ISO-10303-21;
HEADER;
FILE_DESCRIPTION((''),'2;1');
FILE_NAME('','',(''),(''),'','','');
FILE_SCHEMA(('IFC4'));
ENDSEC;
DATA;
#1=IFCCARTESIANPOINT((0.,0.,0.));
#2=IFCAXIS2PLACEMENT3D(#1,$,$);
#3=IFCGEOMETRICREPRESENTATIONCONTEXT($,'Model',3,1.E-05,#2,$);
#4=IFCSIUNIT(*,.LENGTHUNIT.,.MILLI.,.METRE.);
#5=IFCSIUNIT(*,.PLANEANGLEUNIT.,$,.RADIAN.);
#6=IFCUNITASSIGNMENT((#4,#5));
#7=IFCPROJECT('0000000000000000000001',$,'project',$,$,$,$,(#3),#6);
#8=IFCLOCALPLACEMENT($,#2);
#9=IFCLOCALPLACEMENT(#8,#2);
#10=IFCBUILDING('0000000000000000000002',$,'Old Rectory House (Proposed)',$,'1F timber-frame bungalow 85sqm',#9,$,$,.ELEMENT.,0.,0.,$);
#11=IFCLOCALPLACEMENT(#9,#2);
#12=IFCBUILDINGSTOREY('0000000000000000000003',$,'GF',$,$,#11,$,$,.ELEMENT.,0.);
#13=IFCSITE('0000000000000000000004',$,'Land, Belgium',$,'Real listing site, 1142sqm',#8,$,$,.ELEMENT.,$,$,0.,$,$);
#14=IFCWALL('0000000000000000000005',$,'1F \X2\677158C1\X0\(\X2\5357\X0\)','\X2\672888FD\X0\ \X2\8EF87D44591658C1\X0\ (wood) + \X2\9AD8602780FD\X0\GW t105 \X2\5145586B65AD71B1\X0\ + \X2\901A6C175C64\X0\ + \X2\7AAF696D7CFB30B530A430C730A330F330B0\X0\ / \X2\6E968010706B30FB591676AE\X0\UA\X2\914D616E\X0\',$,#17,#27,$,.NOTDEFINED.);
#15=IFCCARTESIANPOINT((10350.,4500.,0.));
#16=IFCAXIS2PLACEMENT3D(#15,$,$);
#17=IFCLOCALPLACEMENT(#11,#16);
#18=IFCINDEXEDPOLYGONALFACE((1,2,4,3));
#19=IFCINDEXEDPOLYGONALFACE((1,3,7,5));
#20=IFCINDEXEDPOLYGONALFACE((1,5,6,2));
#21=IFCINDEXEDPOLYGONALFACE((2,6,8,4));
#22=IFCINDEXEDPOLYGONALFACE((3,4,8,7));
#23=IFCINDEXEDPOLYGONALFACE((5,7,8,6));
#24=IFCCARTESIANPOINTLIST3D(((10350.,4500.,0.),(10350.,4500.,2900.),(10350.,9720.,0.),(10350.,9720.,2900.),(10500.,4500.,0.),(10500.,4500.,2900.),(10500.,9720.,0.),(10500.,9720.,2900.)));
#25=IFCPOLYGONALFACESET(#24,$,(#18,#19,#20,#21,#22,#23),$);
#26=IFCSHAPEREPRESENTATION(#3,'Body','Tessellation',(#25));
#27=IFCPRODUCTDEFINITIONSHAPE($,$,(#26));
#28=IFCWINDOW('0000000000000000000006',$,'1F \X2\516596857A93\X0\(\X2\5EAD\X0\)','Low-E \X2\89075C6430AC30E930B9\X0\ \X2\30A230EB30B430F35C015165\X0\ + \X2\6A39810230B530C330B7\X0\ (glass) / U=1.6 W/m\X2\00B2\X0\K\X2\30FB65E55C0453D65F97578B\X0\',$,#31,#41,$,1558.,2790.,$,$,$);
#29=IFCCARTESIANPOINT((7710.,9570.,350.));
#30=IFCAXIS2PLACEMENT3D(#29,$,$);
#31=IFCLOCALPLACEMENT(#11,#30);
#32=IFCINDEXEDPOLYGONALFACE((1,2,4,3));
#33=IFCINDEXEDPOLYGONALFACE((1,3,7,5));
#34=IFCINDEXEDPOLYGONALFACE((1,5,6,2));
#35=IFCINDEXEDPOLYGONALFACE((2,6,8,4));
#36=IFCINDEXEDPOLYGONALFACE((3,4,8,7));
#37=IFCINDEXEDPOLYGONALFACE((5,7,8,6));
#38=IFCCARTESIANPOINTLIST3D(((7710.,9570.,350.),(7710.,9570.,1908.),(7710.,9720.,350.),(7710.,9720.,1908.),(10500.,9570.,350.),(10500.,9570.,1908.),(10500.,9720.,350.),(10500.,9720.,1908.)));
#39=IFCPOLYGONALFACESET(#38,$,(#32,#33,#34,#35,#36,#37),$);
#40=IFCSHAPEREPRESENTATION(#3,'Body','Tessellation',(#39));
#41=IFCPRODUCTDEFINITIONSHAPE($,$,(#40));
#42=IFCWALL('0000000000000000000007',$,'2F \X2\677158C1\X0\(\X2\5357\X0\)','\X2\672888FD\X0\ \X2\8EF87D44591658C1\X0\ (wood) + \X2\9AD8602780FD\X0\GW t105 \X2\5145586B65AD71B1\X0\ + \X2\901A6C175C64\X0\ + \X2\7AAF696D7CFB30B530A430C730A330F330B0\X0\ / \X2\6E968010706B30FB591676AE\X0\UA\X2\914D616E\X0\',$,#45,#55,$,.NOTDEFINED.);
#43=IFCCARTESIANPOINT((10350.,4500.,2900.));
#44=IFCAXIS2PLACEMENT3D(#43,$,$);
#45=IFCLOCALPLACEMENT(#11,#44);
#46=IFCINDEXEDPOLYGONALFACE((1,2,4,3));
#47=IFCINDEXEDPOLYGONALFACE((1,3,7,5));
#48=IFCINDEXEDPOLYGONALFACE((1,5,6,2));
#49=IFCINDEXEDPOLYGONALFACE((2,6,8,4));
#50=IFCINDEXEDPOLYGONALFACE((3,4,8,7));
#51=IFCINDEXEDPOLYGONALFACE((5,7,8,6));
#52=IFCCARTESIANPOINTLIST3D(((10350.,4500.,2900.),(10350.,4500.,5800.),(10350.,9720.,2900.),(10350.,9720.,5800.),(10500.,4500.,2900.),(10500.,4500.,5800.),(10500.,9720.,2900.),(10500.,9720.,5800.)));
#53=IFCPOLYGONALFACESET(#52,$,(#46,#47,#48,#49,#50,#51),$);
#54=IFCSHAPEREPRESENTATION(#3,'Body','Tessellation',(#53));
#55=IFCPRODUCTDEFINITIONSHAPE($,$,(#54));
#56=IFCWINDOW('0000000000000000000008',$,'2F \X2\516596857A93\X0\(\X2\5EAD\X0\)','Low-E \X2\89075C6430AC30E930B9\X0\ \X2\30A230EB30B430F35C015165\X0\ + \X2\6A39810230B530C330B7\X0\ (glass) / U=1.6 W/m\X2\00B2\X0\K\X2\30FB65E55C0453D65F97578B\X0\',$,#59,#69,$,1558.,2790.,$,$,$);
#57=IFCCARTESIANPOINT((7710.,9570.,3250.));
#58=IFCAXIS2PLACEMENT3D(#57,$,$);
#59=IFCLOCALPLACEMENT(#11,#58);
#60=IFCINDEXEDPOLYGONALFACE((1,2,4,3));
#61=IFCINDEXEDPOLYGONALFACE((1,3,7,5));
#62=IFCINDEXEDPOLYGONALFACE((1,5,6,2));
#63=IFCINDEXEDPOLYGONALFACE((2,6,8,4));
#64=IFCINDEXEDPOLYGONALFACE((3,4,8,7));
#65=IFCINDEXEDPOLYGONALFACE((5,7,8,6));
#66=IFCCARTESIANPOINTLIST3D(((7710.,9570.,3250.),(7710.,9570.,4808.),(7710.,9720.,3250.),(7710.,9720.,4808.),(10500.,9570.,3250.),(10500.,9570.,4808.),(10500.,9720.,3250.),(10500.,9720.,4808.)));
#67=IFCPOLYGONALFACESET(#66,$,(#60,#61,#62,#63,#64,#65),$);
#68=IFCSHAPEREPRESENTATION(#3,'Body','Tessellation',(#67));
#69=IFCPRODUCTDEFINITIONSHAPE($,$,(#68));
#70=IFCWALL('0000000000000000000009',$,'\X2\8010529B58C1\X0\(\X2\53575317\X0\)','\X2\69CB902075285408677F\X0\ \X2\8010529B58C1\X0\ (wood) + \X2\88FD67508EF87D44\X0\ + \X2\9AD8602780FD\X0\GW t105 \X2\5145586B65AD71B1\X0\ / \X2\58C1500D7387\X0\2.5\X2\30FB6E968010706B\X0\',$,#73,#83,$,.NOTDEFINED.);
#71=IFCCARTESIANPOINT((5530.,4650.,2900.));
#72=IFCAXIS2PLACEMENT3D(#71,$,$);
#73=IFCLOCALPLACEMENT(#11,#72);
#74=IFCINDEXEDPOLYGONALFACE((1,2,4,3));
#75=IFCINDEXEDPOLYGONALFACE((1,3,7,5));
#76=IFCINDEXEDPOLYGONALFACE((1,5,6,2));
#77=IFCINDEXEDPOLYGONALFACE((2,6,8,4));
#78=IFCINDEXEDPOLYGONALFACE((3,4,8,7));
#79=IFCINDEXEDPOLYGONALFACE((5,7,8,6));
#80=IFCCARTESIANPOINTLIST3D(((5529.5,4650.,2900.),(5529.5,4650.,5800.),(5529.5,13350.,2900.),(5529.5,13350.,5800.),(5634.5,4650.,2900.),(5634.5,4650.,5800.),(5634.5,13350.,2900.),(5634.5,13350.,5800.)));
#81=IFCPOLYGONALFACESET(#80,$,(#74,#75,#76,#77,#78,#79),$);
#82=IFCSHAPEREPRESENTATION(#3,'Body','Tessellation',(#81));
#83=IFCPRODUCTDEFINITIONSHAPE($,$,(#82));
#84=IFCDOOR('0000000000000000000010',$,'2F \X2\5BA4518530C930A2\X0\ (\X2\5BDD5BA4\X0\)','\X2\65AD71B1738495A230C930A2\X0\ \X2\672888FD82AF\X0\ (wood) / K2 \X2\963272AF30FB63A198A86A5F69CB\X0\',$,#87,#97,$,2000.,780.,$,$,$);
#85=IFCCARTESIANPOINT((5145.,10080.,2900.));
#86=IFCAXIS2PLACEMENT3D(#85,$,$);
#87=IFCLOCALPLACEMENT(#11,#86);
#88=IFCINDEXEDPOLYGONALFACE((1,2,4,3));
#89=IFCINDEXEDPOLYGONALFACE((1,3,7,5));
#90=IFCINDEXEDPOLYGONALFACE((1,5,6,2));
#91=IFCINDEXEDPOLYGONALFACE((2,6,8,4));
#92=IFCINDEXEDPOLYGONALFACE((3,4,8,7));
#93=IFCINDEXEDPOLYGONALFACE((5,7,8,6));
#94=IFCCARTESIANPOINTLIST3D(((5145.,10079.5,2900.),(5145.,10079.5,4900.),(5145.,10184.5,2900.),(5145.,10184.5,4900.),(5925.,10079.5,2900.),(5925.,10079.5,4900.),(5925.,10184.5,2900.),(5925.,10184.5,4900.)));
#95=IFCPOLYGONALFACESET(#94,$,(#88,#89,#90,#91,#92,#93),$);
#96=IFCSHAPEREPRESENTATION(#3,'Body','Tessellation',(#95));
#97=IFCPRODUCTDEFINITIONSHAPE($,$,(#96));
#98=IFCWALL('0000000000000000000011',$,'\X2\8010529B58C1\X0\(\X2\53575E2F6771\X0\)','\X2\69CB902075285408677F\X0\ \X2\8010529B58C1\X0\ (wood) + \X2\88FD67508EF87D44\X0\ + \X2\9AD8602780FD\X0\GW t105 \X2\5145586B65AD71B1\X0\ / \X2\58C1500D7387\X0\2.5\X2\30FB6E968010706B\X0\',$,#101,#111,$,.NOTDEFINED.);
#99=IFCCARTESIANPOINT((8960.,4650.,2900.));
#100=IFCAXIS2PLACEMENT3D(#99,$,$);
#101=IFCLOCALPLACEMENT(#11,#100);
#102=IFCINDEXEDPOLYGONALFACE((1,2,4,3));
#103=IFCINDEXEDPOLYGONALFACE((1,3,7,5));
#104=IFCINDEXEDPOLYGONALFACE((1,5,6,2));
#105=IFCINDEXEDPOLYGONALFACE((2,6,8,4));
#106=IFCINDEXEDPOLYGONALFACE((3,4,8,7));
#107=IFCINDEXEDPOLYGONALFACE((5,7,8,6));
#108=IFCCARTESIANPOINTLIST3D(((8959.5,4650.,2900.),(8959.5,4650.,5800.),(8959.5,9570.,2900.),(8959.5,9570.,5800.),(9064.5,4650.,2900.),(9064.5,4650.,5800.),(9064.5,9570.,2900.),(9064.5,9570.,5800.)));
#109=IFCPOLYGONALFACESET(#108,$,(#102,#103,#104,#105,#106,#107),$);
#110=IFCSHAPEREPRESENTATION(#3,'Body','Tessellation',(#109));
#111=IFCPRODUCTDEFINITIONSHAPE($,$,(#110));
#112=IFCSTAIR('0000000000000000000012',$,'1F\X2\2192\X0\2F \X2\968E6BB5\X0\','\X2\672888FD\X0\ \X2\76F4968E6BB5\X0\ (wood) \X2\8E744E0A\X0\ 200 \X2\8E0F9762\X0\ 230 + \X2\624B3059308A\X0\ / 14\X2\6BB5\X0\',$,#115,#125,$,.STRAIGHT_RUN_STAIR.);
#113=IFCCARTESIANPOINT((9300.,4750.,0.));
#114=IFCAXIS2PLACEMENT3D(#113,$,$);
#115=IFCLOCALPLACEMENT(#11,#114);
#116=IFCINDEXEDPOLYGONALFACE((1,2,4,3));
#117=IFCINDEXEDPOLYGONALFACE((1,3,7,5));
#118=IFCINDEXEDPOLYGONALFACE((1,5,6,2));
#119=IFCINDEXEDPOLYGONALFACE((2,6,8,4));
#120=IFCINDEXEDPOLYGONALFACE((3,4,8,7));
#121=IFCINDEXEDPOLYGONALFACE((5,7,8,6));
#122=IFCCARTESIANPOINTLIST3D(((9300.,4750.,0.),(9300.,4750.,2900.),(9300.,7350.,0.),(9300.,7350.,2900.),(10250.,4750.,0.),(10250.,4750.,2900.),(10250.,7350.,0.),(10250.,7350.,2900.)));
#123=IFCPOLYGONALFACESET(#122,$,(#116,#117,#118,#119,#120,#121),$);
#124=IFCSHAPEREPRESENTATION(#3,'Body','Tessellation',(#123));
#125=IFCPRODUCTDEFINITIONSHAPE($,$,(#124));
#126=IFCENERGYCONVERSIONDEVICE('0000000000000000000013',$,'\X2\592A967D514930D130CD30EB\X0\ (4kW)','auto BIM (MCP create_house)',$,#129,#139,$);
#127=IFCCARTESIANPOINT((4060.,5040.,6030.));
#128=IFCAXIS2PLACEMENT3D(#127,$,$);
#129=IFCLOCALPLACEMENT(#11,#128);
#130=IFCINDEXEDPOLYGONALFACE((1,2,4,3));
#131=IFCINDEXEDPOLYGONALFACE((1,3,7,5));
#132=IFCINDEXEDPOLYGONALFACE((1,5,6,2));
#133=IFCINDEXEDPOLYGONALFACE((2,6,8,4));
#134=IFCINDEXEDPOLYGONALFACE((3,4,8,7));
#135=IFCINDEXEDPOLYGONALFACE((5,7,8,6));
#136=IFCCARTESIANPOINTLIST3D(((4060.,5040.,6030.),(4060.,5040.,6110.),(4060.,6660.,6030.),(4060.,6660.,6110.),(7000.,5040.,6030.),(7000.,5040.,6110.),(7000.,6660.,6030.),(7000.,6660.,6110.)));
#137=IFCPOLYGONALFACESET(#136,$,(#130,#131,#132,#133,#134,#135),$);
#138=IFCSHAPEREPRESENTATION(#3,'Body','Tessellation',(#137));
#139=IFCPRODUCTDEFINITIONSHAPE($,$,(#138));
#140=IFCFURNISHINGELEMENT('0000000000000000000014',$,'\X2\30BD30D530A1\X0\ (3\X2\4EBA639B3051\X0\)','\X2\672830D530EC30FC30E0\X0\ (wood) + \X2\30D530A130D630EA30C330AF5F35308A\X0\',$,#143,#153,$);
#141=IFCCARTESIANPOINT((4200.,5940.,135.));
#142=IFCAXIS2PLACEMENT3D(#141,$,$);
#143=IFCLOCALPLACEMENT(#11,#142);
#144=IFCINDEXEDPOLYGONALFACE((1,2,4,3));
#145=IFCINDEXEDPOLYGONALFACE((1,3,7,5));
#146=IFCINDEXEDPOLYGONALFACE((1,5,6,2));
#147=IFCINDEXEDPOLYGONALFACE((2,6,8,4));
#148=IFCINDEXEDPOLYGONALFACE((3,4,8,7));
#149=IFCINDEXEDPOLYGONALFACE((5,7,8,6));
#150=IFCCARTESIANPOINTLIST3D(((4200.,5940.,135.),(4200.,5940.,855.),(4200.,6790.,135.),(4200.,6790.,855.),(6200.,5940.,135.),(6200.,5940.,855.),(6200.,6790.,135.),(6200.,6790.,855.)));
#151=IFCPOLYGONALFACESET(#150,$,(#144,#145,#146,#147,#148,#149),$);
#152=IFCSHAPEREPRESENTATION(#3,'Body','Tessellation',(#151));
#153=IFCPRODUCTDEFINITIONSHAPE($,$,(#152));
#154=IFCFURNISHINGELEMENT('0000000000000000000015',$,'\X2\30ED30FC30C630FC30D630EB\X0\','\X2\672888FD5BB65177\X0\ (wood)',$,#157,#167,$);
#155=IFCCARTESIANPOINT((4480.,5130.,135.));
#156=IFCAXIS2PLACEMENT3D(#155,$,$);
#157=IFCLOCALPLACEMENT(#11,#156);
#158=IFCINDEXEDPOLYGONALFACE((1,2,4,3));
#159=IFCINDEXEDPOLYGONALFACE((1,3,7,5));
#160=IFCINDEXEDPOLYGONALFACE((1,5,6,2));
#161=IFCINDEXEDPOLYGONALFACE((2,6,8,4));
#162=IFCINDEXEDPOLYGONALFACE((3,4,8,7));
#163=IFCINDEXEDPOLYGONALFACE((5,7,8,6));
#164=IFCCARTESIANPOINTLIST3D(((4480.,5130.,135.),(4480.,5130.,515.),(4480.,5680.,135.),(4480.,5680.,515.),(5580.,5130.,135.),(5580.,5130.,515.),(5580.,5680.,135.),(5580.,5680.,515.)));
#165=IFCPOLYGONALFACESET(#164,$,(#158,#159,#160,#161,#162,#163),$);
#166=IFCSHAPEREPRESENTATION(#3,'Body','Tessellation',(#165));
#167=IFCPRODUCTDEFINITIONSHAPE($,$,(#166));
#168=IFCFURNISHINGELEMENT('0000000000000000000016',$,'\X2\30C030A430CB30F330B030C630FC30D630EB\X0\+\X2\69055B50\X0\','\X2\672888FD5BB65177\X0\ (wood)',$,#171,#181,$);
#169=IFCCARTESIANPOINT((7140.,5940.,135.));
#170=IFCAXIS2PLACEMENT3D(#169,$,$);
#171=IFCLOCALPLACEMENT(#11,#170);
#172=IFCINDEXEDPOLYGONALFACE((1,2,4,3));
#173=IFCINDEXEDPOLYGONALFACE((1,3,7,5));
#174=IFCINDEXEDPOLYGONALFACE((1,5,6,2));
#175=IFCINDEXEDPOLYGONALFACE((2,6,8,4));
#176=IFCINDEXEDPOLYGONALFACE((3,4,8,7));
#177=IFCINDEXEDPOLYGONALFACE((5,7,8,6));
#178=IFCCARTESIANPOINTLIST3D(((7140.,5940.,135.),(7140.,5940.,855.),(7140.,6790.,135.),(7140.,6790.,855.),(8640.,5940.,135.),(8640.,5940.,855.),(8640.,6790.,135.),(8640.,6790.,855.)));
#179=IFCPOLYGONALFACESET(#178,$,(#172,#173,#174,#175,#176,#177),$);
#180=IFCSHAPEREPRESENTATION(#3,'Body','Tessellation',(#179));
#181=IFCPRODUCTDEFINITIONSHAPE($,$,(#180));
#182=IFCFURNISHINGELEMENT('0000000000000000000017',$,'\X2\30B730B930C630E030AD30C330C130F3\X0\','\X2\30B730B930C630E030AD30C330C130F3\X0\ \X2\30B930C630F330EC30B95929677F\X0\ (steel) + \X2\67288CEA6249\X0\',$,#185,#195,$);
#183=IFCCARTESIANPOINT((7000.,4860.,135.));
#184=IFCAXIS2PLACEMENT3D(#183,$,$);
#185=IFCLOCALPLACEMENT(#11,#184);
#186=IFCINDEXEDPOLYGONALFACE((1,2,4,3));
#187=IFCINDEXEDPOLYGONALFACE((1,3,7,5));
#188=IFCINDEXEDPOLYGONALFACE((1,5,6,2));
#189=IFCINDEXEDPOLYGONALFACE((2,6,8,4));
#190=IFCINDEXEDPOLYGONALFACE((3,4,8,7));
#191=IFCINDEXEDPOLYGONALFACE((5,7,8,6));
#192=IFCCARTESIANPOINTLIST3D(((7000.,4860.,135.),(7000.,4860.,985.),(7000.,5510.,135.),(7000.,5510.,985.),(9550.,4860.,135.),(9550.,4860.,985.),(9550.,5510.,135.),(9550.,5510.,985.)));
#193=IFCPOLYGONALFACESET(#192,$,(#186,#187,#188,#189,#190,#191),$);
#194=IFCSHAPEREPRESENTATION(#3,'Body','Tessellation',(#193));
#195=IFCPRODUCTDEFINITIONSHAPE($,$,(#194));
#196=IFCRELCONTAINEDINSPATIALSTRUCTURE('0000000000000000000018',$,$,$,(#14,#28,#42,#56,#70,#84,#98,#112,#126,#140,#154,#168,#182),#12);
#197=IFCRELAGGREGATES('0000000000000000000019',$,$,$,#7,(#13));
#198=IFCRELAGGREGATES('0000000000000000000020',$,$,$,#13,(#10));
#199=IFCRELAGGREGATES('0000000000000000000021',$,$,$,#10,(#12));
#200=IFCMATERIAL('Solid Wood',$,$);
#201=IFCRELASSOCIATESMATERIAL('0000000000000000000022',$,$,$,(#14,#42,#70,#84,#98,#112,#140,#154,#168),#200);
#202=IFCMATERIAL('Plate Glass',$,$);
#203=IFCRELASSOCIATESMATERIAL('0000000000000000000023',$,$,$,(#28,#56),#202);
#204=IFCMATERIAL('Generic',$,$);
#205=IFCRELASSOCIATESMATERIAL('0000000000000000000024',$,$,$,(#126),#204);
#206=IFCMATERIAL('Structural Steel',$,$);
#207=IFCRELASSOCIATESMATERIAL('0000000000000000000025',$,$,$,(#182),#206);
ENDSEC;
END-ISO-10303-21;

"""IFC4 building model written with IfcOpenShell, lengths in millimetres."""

from ifc_helpers import new_model, si_unit, frame, frame_2d, origin, place, context, project, spatial, rectangle, extrude, material, element, fill, save


model = new_model("IFC4")

# Units and contexts
model_context = context("Model", 3, precision=1e-05, world=origin())
ifc_project = project(units=[si_unit("LENGTHUNIT", "METRE", prefix="MILLI"), si_unit("PLANEANGLEUNIT", "RADIAN")], contexts=[model_context])

# Site, building, storey
site_placement = place(None, origin())
site = spatial("IfcSite", under=ifc_project, at=site_placement, Name="Land, Belgium", ObjectType="Real listing site, 1142sqm", CompositionType="ELEMENT", RefElevation=0.0)
building_placement = place(site_placement, origin())
building = spatial("IfcBuilding", under=site, at=building_placement, Name="Old Rectory House (Proposed)", ObjectType="1F timber-frame bungalow 85sqm", CompositionType="ELEMENT", ElevationOfRefHeight=0.0, ElevationOfTerrain=0.0)
storey_placement = place(building_placement, origin())
storey = spatial("IfcBuildingStorey", under=building, at=storey_placement, Name="GF", CompositionType="ELEMENT", Elevation=0.0)

# Wall, opening, window
ifc_material_1 = material(Name="Solid Wood")
wall_1_placement = place(storey_placement, frame((10350.0, 4500.0, 0.0)))
wall_1 = element("IfcWall", 1, at=wall_1_placement, inside=storey, material=ifc_material_1, Name="1F 東壁(南)", Description="木製 軸組外壁 (wood) + 高性能GW t105 充填断熱 + 通気層 + 窯業系サイディング / 準耐火・外皮UA配慮", PredefinedType="NOTDEFINED", context=model_context, shape_type="SweptSolid", body=[
    extrude(rectangle(XDim=150.0, YDim=5220.0, at=frame_2d((75.0, 2610.0))), frame((10350.0, 4500.0, 0.0)), (0.0, 0.0, 1.0), 2900.0),
])
opening_1_placement = place(storey_placement, frame((7710.0, 9570.0, 350.0)))
opening_1 = element("IfcOpeningElement", 2, at=opening_1_placement, cuts=wall_1, PredefinedType="NOTDEFINED", context=model_context, shape_type="SweptSolid", body=[
    extrude(rectangle(XDim=2790.0, YDim=150.0, at=frame_2d((1395.0, 75.0))), frame((7710.0, 9570.0, 350.0)), (0.0, 0.0, 1.0), 1558.0),
])
ifc_material_2 = material(Name="Plate Glass")
window_1_placement = place(storey_placement, frame((7710.0, 9570.0, 350.0)))
window_1 = element("IfcWindow", 3, at=window_1_placement, inside=storey, material=ifc_material_2, Name="1F 入隅窓(庭)", Description="Low-E 複層ガラス アルゴン封入 + 樹脂サッシ (glass) / U=1.6 W/m²K・日射取得型", OverallHeight=1558.0, OverallWidth=2790.0, context=model_context, shape_type="SweptSolid", body=[
    extrude(rectangle(XDim=2790.0, YDim=150.0, at=frame_2d((1395.0, 75.0))), frame((7710.0, 9570.0, 350.0)), (0.0, 0.0, 1.0), 1558.0),
])
fill(opening_1, window_1)

# Wall, opening, window
wall_2_placement = place(storey_placement, frame((10350.0, 4500.0, 2900.0)))
wall_2 = element("IfcWall", 4, at=wall_2_placement, inside=storey, material=ifc_material_1, Name="2F 東壁(南)", Description="木製 軸組外壁 (wood) + 高性能GW t105 充填断熱 + 通気層 + 窯業系サイディング / 準耐火・外皮UA配慮", PredefinedType="NOTDEFINED", context=model_context, shape_type="SweptSolid", body=[
    extrude(rectangle(XDim=150.0, YDim=5220.0, at=frame_2d((75.0, 2610.0))), frame((10350.0, 4500.0, 2900.0)), (0.0, 0.0, 1.0), 2900.0),
])
opening_2_placement = place(storey_placement, frame((7710.0, 9570.0, 3250.0)))
opening_2 = element("IfcOpeningElement", 5, at=opening_2_placement, cuts=wall_2, PredefinedType="NOTDEFINED", context=model_context, shape_type="SweptSolid", body=[
    extrude(rectangle(XDim=2790.0, YDim=150.0, at=frame_2d((1395.0, 75.0))), frame((7710.0, 9570.0, 3250.0)), (0.0, 0.0, 1.0), 1558.0),
])
window_2_placement = place(storey_placement, frame((7710.0, 9570.0, 3250.0)))
window_2 = element("IfcWindow", 6, at=window_2_placement, inside=storey, material=ifc_material_2, Name="2F 入隅窓(庭)", Description="Low-E 複層ガラス アルゴン封入 + 樹脂サッシ (glass) / U=1.6 W/m²K・日射取得型", OverallHeight=1558.0, OverallWidth=2790.0, context=model_context, shape_type="SweptSolid", body=[
    extrude(rectangle(XDim=2790.0, YDim=150.0, at=frame_2d((1395.0, 75.0))), frame((7710.0, 9570.0, 3250.0)), (0.0, 0.0, 1.0), 1558.0),
])
fill(opening_2, window_2)

# Wall, opening, door
wall_3_placement = place(storey_placement, frame((5530.0, 4650.0, 2900.0)))
wall_3 = element("IfcWall", 7, at=wall_3_placement, inside=storey, material=ifc_material_1, Name="耐力壁(南北)", Description="構造用合板 耐力壁 (wood) + 製材軸組 + 高性能GW t105 充填断熱 / 壁倍率2.5・準耐火", PredefinedType="NOTDEFINED", context=model_context, shape_type="SweptSolid", body=[
    extrude(rectangle(XDim=105.0, YDim=8700.0, at=frame_2d((52.0, 4350.0))), frame((5530.0, 4650.0, 2900.0)), (0.0, 0.0, 1.0), 2900.0),
])
opening_3_placement = place(storey_placement, frame((5145.0, 10080.0, 2900.0)))
opening_3 = element("IfcOpeningElement", 8, at=opening_3_placement, cuts=wall_3, PredefinedType="NOTDEFINED", context=model_context, shape_type="SweptSolid", body=[
    extrude(rectangle(XDim=780.0, YDim=105.0, at=frame_2d((390.0, 52.0))), frame((5145.0, 10080.0, 2900.0)), (0.0, 0.0, 1.0), 2000.0),
])
door_1_placement = place(storey_placement, frame((5145.0, 10080.0, 2900.0)))
door_1 = element("IfcDoor", 9, at=door_1_placement, inside=storey, material=ifc_material_1, Name="2F 室内ドア (寝室)", Description="断熱玄関ドア 木製芯 (wood) / K2 防犯・採風機構", OverallHeight=2000.0, OverallWidth=780.0, context=model_context, shape_type="SweptSolid", body=[
    extrude(rectangle(XDim=780.0, YDim=105.0, at=frame_2d((390.0, 52.0))), frame((5145.0, 10080.0, 2900.0)), (0.0, 0.0, 1.0), 2000.0),
])
fill(opening_3, door_1)

# Wall
wall_4_placement = place(storey_placement, frame((8960.0, 4650.0, 2900.0)))
element("IfcWall", 10, at=wall_4_placement, inside=storey, material=ifc_material_1, Name="耐力壁(南帯東)", Description="構造用合板 耐力壁 (wood) + 製材軸組 + 高性能GW t105 充填断熱 / 壁倍率2.5・準耐火", PredefinedType="NOTDEFINED", context=model_context, shape_type="SweptSolid", body=[
    extrude(rectangle(XDim=105.0, YDim=4920.0, at=frame_2d((52.0, 2460.0))), frame((8960.0, 4650.0, 2900.0)), (0.0, 0.0, 1.0), 2900.0),
])

# Stair
stair_placement = place(storey_placement, frame((9300.0, 4750.0, 0.0)))
element("IfcStair", 11, at=stair_placement, inside=storey, material=ifc_material_1, Name="1F→2F 階段", Description="木製 直階段 (wood) 蹴上 200 踏面 230 + 手すり / 14段", PredefinedType="STRAIGHT_RUN_STAIR", context=model_context, shape_type="SweptSolid", body=[
    extrude(rectangle(XDim=950.0, YDim=2600.0, at=frame_2d((475.0, 1300.0))), frame((9300.0, 4750.0, 0.0)), (0.0, 0.0, 1.0), 2900.0),
])

# Energy conversion device
ifc_material_3 = material(Name="Generic")
energy_conversion_device_placement = place(storey_placement, frame((4060.0, 5040.0, 6030.0)))
element("IfcEnergyConversionDevice", 12, at=energy_conversion_device_placement, inside=storey, material=ifc_material_3, Name="太陽光パネル (4kW)", Description="auto BIM (MCP create_house)", context=model_context, shape_type="SweptSolid", body=[
    extrude(rectangle(XDim=2940.0, YDim=1620.0, at=frame_2d((1470.0, 810.0))), frame((4060.0, 5040.0, 6030.0)), (0.0, 0.0, 1.0), 80.0),
])

# Furnishing elements
furnishing_1_placement = place(storey_placement, frame((4200.0, 5940.0, 135.0)))
element("IfcFurnishingElement", 13, at=furnishing_1_placement, inside=storey, material=ifc_material_1, Name="ソファ (3人掛け)", Description="木フレーム (wood) + ファブリック張り", context=model_context, shape_type="SweptSolid", body=[
    extrude(rectangle(XDim=2000.0, YDim=850.0, at=frame_2d((1000.0, 425.0))), frame((4200.0, 5940.0, 135.0)), (0.0, 0.0, 1.0), 720.0),
])
furnishing_2_placement = place(storey_placement, frame((4480.0, 5130.0, 135.0)))
element("IfcFurnishingElement", 14, at=furnishing_2_placement, inside=storey, material=ifc_material_1, Name="ローテーブル", Description="木製家具 (wood)", context=model_context, shape_type="SweptSolid", body=[
    extrude(rectangle(XDim=1100.0, YDim=550.0, at=frame_2d((550.0, 275.0))), frame((4480.0, 5130.0, 135.0)), (0.0, 0.0, 1.0), 380.0),
])
furnishing_3_placement = place(storey_placement, frame((7140.0, 5940.0, 135.0)))
element("IfcFurnishingElement", 15, at=furnishing_3_placement, inside=storey, material=ifc_material_1, Name="ダイニングテーブル+椅子", Description="木製家具 (wood)", context=model_context, shape_type="SweptSolid", body=[
    extrude(rectangle(XDim=1500.0, YDim=850.0, at=frame_2d((750.0, 425.0))), frame((7140.0, 5940.0, 135.0)), (0.0, 0.0, 1.0), 720.0),
])
ifc_material_4 = material(Name="Structural Steel")
furnishing_4_placement = place(storey_placement, frame((7000.0, 4860.0, 135.0)))
element("IfcFurnishingElement", 16, at=furnishing_4_placement, inside=storey, material=ifc_material_4, Name="システムキッチン", Description="システムキッチン ステンレス天板 (steel) + 木質扉", context=model_context, shape_type="SweptSolid", body=[
    extrude(rectangle(XDim=2550.0, YDim=650.0, at=frame_2d((1275.0, 325.0))), frame((7000.0, 4860.0, 135.0)), (0.0, 0.0, 1.0), 850.0),
])

save(model, "model.ifc")
